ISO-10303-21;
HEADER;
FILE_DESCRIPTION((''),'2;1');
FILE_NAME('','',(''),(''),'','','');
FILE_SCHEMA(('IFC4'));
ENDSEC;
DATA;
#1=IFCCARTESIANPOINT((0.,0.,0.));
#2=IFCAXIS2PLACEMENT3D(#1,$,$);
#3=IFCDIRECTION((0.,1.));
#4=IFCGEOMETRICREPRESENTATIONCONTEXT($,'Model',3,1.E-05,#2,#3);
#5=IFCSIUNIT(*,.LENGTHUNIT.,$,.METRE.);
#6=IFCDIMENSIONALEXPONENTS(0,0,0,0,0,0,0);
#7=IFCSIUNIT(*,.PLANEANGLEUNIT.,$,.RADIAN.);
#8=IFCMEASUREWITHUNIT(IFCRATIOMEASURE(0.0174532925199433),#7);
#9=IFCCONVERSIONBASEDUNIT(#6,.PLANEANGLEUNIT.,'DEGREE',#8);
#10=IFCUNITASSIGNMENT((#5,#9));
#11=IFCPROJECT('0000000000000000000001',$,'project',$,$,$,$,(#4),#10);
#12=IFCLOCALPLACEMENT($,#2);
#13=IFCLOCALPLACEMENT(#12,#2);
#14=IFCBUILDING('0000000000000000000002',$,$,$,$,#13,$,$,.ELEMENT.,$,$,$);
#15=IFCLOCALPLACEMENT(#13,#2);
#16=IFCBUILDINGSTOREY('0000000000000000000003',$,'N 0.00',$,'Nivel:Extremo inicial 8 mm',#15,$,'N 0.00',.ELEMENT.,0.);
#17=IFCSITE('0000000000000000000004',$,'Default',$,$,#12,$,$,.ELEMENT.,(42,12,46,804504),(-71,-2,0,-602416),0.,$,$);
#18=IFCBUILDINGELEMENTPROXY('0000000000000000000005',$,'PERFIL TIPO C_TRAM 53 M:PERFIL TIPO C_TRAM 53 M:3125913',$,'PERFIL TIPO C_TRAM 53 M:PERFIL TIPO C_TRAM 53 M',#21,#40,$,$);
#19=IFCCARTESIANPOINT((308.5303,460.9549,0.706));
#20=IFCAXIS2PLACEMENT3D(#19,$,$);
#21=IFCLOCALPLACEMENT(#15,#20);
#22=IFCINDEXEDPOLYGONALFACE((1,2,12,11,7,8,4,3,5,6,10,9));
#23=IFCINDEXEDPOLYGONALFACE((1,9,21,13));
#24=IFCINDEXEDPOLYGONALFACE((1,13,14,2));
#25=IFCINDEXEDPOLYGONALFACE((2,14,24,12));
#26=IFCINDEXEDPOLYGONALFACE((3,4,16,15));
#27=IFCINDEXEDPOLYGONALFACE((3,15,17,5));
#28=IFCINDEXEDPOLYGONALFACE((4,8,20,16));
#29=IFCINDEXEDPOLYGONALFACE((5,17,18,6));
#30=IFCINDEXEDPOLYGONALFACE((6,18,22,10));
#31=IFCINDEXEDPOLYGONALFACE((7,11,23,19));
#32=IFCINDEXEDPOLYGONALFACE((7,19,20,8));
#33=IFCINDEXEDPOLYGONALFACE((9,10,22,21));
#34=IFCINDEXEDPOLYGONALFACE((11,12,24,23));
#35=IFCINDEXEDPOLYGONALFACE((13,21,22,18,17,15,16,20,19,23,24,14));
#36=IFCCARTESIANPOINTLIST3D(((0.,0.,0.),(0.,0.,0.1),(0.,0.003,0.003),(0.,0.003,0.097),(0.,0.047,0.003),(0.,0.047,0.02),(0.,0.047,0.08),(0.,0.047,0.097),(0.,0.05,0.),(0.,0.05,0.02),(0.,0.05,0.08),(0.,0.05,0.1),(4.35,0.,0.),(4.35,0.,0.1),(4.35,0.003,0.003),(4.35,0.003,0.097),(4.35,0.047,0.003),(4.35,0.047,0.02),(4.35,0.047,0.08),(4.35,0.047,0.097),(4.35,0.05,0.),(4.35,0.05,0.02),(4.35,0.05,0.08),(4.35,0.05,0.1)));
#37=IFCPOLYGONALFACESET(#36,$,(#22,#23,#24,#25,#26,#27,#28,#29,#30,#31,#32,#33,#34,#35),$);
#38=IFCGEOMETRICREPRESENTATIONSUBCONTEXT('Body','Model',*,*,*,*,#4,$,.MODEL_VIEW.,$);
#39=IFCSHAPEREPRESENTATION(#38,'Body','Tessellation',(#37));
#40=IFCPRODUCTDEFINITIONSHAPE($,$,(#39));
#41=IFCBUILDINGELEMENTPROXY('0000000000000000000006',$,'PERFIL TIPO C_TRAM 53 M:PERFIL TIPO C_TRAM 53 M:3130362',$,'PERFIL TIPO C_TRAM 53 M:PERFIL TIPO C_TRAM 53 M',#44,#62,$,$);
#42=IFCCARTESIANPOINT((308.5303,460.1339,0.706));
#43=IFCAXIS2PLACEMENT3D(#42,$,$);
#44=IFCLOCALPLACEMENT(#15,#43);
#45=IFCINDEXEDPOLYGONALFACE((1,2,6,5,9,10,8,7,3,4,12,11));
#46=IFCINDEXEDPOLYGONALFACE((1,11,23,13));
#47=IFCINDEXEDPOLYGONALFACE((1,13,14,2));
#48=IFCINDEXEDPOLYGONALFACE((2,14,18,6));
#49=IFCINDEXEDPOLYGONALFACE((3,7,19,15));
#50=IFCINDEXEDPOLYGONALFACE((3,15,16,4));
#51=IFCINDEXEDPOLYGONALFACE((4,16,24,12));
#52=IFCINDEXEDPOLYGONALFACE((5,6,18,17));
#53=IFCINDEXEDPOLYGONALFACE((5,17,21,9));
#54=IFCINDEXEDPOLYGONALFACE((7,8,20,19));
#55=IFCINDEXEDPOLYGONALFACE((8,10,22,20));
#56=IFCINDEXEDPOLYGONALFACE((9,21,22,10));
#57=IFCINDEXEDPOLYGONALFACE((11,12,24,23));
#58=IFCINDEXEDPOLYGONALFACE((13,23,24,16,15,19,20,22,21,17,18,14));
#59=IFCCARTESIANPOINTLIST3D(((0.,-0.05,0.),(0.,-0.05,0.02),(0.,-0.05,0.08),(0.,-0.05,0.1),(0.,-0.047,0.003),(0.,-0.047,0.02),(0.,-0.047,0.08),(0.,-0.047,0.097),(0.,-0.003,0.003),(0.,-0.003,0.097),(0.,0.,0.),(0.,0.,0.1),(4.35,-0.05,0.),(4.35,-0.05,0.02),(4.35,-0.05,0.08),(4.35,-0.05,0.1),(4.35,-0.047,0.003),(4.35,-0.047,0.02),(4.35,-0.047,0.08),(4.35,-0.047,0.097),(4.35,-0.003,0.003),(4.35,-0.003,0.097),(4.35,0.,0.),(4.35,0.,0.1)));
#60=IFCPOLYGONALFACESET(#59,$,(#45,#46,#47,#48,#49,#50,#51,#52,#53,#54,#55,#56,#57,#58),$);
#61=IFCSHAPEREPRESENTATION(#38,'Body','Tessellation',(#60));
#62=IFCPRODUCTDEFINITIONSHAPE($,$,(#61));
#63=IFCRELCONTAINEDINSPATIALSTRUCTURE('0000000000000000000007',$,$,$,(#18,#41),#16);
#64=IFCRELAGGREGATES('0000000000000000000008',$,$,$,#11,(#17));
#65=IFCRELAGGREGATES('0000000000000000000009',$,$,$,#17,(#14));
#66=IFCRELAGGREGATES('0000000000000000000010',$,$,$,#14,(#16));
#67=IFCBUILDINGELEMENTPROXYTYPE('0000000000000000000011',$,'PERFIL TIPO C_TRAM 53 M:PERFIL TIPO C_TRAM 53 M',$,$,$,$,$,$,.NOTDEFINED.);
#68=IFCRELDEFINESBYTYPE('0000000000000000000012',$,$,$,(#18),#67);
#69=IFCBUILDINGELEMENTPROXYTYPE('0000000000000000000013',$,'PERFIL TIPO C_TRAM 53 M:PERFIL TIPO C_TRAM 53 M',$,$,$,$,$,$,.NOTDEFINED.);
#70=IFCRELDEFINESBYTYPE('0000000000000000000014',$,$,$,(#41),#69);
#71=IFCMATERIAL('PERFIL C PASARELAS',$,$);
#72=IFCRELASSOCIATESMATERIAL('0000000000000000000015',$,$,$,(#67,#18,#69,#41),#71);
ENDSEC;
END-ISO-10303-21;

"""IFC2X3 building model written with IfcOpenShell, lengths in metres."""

from ifc_helpers import new_model, entity, si_unit, converted_unit, direction, frame, origin, place, context, subcontext, project, spatial, polyline, outline, extrude, source, transform, mapped, material, type_object, type_shapes, element, save


model = new_model("IFC2X3")

# Units and contexts
model_context = context("Model", 3, precision=1e-05, world=origin(), true_north=direction((0.0, 1.0)))
body_context = subcontext(model_context, "Body", "Model", "MODEL_VIEW")
ifc_project = project(units=[si_unit("LENGTHUNIT", "METRE"), converted_unit("PLANEANGLEUNIT", "DEGREE", entity("IfcRatioMeasure", 0.0174532925199433), si_unit("PLANEANGLEUNIT", "RADIAN"), dimensions=[0, 0, 0, 0, 0, 0, 0])], contexts=[model_context])

# Site, building, storey
site_placement = place(None, origin())
site = spatial("IfcSite", under=ifc_project, at=site_placement, Name="Default", CompositionType="ELEMENT", RefLatitude=(42, 12, 46, 804504), RefLongitude=(-71, -2, 0, -602416), RefElevation=0.0)
building_placement = place(site_placement, origin())
building = spatial("IfcBuilding", under=site, at=building_placement, CompositionType="ELEMENT")
storey_placement = place(building_placement, origin())
storey = spatial("IfcBuildingStorey", under=building, at=storey_placement, Name="N 0.00", ObjectType="Nivel:Extremo inicial 8 mm", LongName="N 0.00", CompositionType="ELEMENT", Elevation=0.0)

# Building element proxies
ifc_material_1 = material(Name="PERFIL C PASARELAS")
building_element_proxy_type_1 = type_object("IfcBuildingElementProxyType", Name="PERFIL TIPO C_TRAM 53 M:PERFIL TIPO C_TRAM 53 M", PredefinedType="NOTDEFINED", material=ifc_material_1)
shared_shape_1 = source(origin(), body_context, "Body", "SweptSolid", [
    extrude(outline(polyline([(-0.0172, 0.03), (-0.0142, 0.03), (-0.0142, 0.047), (0.0298, 0.047), (0.0298, -0.047), (-0.0142, -0.047), (-0.0142, -0.03), (-0.0172, -0.03), (-0.0172, -0.05), (0.0328, -0.05), (0.0328, 0.05), (-0.0172, 0.05), (-0.0172, 0.03)])), frame((0.0, 0.0328, 0.05), z_axis=(1.0, 0.0, 0.0), x_axis=(0.0, -1.0, 0.0)), (0.0, 0.0, 1.0), 4.35),
])
type_shapes(building_element_proxy_type_1, [shared_shape_1])
proxy_1_placement = place(storey_placement, frame((308.5303, 460.9549, 0.706)))
element("IfcBuildingElementProxy", 1, at=proxy_1_placement, inside=storey, type_object=building_element_proxy_type_1, material=ifc_material_1, Name="PERFIL TIPO C_TRAM 53 M:PERFIL TIPO C_TRAM 53 M:3125913", ObjectType="PERFIL TIPO C_TRAM 53 M:PERFIL TIPO C_TRAM 53 M", context=body_context, shape_type="MappedRepresentation", body=[
    mapped(shared_shape_1, transform((0.0, 0.0, 0.0), scale=1.0)),
])
building_element_proxy_type_2 = type_object("IfcBuildingElementProxyType", Name="PERFIL TIPO C_TRAM 53 M:PERFIL TIPO C_TRAM 53 M", PredefinedType="NOTDEFINED", material=ifc_material_1)
shared_shape_2 = source(origin(), body_context, "Body", "SweptSolid", [
    extrude(outline(polyline([(0.03, -0.0172), (0.05, -0.0172), (0.05, 0.0328), (-0.05, 0.0328), (-0.05, -0.0172), (-0.03, -0.0172), (-0.03, -0.0142), (-0.047, -0.0142), (-0.047, 0.0298), (0.047, 0.0298), (0.047, -0.0142), (0.03, -0.0142), (0.03, -0.0172)])), frame((0.0, -0.0328, 0.05), z_axis=(1.0, 0.0, 0.0), x_axis=(0.0, 0.0, -1.0)), (0.0, 0.0, 1.0), 4.35),
])
type_shapes(building_element_proxy_type_2, [shared_shape_2])
proxy_2_placement = place(storey_placement, frame((308.5303, 460.1339, 0.706)))
element("IfcBuildingElementProxy", 2, at=proxy_2_placement, inside=storey, type_object=building_element_proxy_type_2, material=ifc_material_1, Name="PERFIL TIPO C_TRAM 53 M:PERFIL TIPO C_TRAM 53 M:3130362", ObjectType="PERFIL TIPO C_TRAM 53 M:PERFIL TIPO C_TRAM 53 M", context=body_context, shape_type="MappedRepresentation", body=[
    mapped(shared_shape_2, transform((0.0, 0.0, 0.0), scale=1.0)),
])

save(model, "model.ifc")
